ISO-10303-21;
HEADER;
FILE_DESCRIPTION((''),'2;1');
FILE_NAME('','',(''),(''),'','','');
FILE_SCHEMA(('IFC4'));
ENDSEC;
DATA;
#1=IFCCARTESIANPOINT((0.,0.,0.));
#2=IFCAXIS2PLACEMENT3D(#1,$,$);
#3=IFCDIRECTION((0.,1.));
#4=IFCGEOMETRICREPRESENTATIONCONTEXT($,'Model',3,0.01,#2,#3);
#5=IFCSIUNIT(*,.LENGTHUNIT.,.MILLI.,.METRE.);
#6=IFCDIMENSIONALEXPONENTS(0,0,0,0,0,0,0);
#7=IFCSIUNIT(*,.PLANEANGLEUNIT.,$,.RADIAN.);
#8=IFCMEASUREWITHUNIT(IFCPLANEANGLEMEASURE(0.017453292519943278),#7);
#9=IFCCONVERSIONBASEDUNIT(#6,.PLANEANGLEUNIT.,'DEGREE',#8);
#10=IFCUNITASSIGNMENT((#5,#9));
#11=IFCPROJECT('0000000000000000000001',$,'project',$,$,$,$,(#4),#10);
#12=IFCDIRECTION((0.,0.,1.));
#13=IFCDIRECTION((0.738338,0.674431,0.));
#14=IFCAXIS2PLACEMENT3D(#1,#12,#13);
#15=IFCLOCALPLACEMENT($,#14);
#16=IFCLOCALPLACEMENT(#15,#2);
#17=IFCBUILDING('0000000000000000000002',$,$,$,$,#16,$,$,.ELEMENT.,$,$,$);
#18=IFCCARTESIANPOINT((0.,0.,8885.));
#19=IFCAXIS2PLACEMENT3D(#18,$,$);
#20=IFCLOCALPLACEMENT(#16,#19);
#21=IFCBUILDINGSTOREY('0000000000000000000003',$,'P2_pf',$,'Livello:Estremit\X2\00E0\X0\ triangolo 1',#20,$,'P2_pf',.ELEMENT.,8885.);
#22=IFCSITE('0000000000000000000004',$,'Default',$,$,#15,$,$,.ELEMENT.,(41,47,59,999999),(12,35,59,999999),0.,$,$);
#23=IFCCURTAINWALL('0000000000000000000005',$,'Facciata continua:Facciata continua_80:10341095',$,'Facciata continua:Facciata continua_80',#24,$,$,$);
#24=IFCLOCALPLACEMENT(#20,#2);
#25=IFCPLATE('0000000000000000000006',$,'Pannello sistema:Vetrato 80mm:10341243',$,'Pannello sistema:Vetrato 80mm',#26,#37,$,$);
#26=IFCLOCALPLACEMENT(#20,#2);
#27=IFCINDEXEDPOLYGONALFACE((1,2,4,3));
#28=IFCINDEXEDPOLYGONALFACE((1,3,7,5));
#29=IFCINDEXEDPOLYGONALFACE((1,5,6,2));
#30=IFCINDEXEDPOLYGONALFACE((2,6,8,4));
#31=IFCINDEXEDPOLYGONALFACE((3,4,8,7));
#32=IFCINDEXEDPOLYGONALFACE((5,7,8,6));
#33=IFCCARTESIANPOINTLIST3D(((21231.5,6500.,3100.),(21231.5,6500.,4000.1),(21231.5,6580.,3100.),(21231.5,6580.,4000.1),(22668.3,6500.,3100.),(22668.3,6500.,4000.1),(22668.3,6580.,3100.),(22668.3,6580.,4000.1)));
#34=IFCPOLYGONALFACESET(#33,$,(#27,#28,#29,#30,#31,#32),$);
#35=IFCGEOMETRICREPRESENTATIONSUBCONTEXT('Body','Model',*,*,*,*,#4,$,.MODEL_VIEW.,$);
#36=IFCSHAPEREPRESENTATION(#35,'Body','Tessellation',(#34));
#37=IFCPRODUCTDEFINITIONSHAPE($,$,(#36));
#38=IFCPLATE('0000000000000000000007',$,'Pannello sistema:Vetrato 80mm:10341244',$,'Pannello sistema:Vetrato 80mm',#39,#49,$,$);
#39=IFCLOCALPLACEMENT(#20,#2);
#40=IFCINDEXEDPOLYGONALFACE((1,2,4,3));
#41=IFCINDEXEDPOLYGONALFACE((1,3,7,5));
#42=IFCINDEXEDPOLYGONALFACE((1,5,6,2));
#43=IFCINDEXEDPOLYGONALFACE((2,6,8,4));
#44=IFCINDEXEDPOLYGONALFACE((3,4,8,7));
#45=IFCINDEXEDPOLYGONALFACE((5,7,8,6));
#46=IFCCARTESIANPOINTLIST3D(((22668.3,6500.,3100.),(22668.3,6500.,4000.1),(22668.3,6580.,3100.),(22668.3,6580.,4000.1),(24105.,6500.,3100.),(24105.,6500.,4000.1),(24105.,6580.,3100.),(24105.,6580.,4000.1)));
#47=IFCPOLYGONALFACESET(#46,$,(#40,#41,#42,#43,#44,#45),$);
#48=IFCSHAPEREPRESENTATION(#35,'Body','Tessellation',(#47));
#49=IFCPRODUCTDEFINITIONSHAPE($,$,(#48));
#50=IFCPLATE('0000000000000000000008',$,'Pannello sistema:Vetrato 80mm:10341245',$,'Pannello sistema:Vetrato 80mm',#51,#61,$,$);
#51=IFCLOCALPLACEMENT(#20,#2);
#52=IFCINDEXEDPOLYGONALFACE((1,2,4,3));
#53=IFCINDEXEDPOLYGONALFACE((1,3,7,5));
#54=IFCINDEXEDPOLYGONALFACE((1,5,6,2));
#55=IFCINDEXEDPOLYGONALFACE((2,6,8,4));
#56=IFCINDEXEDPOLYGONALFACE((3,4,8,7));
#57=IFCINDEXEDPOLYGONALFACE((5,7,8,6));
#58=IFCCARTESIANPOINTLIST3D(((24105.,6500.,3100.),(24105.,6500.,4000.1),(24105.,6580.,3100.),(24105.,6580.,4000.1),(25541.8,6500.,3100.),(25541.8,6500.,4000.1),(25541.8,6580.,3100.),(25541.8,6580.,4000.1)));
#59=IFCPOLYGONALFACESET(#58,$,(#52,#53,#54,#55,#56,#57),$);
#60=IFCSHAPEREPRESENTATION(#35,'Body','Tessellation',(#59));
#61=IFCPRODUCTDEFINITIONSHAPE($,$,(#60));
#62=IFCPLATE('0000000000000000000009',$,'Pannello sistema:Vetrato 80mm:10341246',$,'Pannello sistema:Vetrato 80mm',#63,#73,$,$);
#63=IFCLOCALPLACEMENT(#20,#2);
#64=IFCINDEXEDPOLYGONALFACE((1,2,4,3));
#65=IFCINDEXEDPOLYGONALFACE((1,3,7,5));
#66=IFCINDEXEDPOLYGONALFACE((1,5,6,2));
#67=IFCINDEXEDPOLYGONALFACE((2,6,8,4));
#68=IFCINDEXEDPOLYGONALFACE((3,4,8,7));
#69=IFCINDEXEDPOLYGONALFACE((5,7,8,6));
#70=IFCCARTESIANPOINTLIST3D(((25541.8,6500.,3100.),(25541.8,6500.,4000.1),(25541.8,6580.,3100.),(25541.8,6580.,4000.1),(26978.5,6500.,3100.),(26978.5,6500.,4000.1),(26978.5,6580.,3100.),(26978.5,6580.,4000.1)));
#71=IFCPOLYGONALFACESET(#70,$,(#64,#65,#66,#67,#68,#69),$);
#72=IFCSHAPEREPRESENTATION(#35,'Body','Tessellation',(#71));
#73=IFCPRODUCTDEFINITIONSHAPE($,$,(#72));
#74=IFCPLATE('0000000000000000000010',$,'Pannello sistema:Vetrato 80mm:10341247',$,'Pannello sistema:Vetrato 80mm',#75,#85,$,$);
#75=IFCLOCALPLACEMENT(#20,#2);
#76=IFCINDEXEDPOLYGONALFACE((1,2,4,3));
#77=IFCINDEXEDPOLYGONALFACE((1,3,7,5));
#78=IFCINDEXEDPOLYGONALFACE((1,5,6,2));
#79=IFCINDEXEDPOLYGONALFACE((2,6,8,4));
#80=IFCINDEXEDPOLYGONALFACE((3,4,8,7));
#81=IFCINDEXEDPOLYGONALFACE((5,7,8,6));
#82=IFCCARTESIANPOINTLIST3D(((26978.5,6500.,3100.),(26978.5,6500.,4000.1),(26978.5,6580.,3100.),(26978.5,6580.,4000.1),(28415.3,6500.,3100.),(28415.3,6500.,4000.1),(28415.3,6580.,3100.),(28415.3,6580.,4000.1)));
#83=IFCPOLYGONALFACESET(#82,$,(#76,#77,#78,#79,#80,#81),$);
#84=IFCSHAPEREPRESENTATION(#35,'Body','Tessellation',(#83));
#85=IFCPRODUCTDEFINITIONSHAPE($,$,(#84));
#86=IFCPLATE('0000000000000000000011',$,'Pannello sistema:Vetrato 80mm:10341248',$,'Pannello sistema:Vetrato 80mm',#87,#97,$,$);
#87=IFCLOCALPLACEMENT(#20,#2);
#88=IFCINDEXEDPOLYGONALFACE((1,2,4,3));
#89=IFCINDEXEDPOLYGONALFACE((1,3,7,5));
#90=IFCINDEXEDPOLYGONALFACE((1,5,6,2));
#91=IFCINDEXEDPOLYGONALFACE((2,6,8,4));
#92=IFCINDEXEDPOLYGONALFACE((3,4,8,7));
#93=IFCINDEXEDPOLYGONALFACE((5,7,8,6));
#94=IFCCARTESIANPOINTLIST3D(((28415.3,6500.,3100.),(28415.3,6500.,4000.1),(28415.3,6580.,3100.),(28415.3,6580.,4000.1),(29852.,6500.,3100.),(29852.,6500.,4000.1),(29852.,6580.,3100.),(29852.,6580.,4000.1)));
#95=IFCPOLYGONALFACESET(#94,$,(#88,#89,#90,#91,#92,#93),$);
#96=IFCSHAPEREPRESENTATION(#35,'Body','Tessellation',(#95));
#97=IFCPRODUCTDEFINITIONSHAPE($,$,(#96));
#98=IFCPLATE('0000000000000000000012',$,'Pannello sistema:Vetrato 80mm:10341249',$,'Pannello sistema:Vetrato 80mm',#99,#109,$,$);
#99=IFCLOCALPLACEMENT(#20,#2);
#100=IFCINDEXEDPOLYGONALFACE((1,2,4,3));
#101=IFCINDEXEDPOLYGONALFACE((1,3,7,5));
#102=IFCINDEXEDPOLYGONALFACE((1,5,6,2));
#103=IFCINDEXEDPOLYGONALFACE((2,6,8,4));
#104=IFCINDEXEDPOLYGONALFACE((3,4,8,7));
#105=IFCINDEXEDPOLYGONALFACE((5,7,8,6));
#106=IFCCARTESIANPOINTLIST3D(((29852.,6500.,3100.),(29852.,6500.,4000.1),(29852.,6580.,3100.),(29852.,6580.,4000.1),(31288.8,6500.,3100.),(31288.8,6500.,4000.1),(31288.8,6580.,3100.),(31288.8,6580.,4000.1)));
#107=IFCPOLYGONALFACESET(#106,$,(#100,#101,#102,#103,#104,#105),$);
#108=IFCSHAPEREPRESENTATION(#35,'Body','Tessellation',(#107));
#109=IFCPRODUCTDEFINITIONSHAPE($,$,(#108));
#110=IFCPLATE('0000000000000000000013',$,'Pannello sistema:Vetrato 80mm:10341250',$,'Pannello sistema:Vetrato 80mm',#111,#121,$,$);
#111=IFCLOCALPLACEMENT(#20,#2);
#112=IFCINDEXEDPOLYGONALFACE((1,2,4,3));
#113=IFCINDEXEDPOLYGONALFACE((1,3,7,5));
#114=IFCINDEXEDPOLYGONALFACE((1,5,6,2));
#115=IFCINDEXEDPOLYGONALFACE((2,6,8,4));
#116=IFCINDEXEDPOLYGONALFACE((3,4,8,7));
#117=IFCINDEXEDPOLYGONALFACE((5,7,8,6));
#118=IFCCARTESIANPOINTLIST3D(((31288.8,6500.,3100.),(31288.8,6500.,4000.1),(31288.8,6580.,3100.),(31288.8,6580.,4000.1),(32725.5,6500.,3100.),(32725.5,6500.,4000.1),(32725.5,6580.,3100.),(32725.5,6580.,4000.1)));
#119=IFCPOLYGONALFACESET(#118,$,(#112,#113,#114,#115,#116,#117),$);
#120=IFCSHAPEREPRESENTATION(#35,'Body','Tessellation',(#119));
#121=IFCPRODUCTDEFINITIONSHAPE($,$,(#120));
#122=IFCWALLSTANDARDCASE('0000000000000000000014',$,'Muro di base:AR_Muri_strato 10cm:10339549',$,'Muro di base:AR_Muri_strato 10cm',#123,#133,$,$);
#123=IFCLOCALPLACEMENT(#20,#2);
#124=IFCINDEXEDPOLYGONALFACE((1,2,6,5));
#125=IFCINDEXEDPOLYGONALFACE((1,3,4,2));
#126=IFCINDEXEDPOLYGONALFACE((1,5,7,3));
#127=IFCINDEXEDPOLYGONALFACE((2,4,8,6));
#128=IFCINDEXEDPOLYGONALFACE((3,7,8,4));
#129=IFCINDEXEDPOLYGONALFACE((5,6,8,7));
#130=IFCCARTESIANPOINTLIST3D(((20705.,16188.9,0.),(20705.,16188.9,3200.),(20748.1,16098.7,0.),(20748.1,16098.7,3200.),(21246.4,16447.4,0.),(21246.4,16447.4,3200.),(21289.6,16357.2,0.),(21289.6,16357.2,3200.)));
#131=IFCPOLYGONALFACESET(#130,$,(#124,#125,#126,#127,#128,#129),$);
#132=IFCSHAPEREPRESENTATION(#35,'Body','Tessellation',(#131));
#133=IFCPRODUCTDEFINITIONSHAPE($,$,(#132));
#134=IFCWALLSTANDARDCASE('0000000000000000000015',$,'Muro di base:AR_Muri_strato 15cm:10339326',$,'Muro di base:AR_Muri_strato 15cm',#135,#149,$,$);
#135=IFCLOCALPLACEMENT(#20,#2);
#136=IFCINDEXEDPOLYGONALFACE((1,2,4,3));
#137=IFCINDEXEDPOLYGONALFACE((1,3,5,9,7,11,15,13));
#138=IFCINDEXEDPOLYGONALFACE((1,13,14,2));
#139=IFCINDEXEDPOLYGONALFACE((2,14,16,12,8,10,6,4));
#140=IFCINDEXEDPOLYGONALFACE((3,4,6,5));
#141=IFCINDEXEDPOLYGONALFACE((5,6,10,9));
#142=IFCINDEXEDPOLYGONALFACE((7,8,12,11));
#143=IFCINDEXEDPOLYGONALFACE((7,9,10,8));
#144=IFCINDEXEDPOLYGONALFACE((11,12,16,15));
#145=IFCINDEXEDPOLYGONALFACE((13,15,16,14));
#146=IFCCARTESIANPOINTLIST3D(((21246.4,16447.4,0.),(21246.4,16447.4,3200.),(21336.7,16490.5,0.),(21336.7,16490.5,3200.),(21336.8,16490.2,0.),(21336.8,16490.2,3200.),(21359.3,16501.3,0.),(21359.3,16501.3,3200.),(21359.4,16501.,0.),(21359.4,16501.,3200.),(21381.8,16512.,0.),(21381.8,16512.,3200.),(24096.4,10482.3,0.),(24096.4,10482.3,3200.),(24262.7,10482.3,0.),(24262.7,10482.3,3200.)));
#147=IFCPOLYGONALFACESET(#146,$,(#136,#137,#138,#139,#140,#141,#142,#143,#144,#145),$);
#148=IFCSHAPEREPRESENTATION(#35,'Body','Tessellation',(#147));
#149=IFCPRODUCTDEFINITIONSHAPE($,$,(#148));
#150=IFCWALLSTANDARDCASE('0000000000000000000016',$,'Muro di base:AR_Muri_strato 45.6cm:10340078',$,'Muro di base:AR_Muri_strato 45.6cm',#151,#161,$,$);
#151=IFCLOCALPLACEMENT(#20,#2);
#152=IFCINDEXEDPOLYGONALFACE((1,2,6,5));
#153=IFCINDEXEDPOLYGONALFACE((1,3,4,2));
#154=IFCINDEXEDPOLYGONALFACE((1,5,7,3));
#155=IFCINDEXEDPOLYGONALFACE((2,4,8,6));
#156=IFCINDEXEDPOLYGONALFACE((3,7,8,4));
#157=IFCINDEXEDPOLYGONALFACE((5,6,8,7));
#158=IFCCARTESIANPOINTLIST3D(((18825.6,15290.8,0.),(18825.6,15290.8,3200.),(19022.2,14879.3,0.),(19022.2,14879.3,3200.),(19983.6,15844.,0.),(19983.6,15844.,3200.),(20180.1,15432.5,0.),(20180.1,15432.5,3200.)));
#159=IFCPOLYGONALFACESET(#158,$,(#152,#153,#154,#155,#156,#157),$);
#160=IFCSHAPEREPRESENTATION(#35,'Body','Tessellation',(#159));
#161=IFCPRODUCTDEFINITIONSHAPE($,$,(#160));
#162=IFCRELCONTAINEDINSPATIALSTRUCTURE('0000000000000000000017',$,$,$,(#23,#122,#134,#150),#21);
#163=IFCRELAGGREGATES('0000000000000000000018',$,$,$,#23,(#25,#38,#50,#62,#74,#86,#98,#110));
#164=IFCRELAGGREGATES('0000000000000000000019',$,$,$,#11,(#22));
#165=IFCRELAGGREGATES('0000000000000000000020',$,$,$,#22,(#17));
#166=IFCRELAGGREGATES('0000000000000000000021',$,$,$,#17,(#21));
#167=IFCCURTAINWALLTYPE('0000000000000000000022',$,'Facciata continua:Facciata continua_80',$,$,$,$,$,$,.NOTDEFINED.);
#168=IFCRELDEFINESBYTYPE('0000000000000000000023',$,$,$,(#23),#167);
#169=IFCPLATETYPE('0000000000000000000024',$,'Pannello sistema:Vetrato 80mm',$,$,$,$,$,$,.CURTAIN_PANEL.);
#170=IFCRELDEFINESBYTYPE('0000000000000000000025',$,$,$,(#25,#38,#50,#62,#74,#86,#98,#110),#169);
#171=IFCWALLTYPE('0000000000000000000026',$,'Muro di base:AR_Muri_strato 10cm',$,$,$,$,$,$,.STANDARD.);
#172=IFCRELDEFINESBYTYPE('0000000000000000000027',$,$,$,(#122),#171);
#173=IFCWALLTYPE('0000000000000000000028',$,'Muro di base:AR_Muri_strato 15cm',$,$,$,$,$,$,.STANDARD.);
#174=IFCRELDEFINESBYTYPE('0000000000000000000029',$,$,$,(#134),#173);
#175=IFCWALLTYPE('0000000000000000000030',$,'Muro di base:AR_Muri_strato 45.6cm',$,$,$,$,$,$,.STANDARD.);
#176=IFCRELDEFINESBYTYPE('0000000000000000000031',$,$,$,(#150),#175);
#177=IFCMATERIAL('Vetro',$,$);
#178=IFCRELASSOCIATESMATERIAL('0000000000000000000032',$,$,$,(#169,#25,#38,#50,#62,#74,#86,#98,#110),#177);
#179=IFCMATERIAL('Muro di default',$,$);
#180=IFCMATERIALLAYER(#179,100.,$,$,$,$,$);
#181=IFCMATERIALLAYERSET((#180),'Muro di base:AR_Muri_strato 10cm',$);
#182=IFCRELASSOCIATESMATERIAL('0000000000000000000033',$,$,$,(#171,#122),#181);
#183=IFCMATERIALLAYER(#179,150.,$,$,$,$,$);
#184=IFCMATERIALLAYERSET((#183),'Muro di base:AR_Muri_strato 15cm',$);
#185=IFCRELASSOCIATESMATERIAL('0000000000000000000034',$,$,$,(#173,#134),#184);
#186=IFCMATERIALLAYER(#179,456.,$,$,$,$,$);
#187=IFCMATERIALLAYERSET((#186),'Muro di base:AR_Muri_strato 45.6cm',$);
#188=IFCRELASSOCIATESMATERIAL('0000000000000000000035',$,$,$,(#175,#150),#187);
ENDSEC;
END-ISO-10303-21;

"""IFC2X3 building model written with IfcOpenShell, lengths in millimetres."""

from ifc_helpers import new_model, entity, si_unit, converted_unit, direction, frame, frame_2d, origin, origin_2d_with_axis, place, context, subcontext, project, spatial, polyline, rectangle, outline, extrude, clip, bounded_halfspace, source, transform, mapped, material, layer, layer_set, layer_usage, type_object, type_shapes, element, aggregate, save


model = new_model("IFC2X3")

# Units and contexts
model_context = context("Model", 3, precision=0.01, world=origin(), true_north=direction((0.0, 1.0)))
body_context = subcontext(model_context, "Body", "Model", "MODEL_VIEW")
ifc_project = project(units=[si_unit("LENGTHUNIT", "METRE", prefix="MILLI"), converted_unit("PLANEANGLEUNIT", "DEGREE", entity("IfcPlaneAngleMeasure", 0.017453292519943278), si_unit("PLANEANGLEUNIT", "RADIAN"), dimensions=[0, 0, 0, 0, 0, 0, 0])], contexts=[model_context])

# Site, building, storey
site_placement = place(None, frame((0.0, 0.0, 0.0), z_axis=(0.0, 0.0, 1.0), x_axis=(0.738338, 0.674431, 0.0)))
site = spatial("IfcSite", under=ifc_project, at=site_placement, Name="Default", CompositionType="ELEMENT", RefLatitude=(41, 47, 59, 999999), RefLongitude=(12, 35, 59, 999999), RefElevation=0.0)
building_placement = place(site_placement, origin())
building = spatial("IfcBuilding", under=site, at=building_placement, CompositionType="ELEMENT")
storey_placement = place(building_placement, frame((0.0, 0.0, 8885.0)))
storey = spatial("IfcBuildingStorey", under=building, at=storey_placement, Name="P2_pf", ObjectType="Livello:Estremità triangolo 1", LongName="P2_pf", CompositionType="ELEMENT", Elevation=8885.0)

# Shared definitions
ifc_material_1 = material(Name="Vetro")

# Curtain wall, plates
curtain_wall_type_1 = type_object("IfcCurtainWallType", Name="Facciata continua:Facciata continua_80", PredefinedType="NOTDEFINED")
curtain_wall_1_placement = place(storey_placement, frame((0.0, 0.0, -8885.0)))
curtain_wall_1 = element("IfcCurtainWall", 1, at=curtain_wall_1_placement, inside=storey, type_object=curtain_wall_type_1, Name="Facciata continua:Facciata continua_80:10341095", ObjectType="Facciata continua:Facciata continua_80")
plate_type_1 = type_object("IfcPlateType", Name="Pannello sistema:Vetrato 80mm", PredefinedType="CURTAIN_PANEL", material=ifc_material_1)
shared_shape_1 = source(origin(), body_context, "Body", "SweptSolid", [
    extrude(rectangle(XDim=80.0, YDim=1436.8, at=origin_2d_with_axis()), frame((0.0, -40.0, 0.0), z_axis=(0.0, 0.0, 1.0), x_axis=(0.0, 1.0, 0.0)), (0.0, 0.0, 1.0), 900.1),
])
type_shapes(plate_type_1, [shared_shape_1])
plate_1_placement = place(curtain_wall_1_placement, frame((21949.9, 6580.0, 11985.0)))
plate_1 = element("IfcPlate", 2, at=plate_1_placement, type_object=plate_type_1, material=ifc_material_1, Name="Pannello sistema:Vetrato 80mm:10341243", ObjectType="Pannello sistema:Vetrato 80mm", context=body_context, shape_type="MappedRepresentation", body=[
    mapped(shared_shape_1, transform((0.0, 0.0, 0.0), scale=1.0)),
])
plate_2_placement = place(curtain_wall_1_placement, frame((23386.6, 6580.0, 11985.0)))
plate_2 = element("IfcPlate", 3, at=plate_2_placement, type_object=plate_type_1, material=ifc_material_1, Name="Pannello sistema:Vetrato 80mm:10341244", ObjectType="Pannello sistema:Vetrato 80mm", context=body_context, shape_type="MappedRepresentation", body=[
    mapped(shared_shape_1, transform((0.0, 0.0, 0.0), scale=1.0)),
])
plate_3_placement = place(curtain_wall_1_placement, frame((24823.4, 6580.0, 11985.0)))
plate_3 = element("IfcPlate", 4, at=plate_3_placement, type_object=plate_type_1, material=ifc_material_1, Name="Pannello sistema:Vetrato 80mm:10341245", ObjectType="Pannello sistema:Vetrato 80mm", context=body_context, shape_type="MappedRepresentation", body=[
    mapped(shared_shape_1, transform((0.0, 0.0, 0.0), scale=1.0)),
])
plate_4_placement = place(curtain_wall_1_placement, frame((26260.2, 6580.0, 11985.0)))
plate_4 = element("IfcPlate", 5, at=plate_4_placement, type_object=plate_type_1, material=ifc_material_1, Name="Pannello sistema:Vetrato 80mm:10341246", ObjectType="Pannello sistema:Vetrato 80mm", context=body_context, shape_type="MappedRepresentation", body=[
    mapped(shared_shape_1, transform((0.0, 0.0, 0.0), scale=1.0)),
])
plate_5_placement = place(curtain_wall_1_placement, frame((27696.9, 6580.0, 11985.0)))
plate_5 = element("IfcPlate", 6, at=plate_5_placement, type_object=plate_type_1, material=ifc_material_1, Name="Pannello sistema:Vetrato 80mm:10341247", ObjectType="Pannello sistema:Vetrato 80mm", context=body_context, shape_type="MappedRepresentation", body=[
    mapped(shared_shape_1, transform((0.0, 0.0, 0.0), scale=1.0)),
])
plate_6_placement = place(curtain_wall_1_placement, frame((29133.7, 6580.0, 11985.0)))
plate_6 = element("IfcPlate", 7, at=plate_6_placement, type_object=plate_type_1, material=ifc_material_1, Name="Pannello sistema:Vetrato 80mm:10341248", ObjectType="Pannello sistema:Vetrato 80mm", context=body_context, shape_type="MappedRepresentation", body=[
    mapped(shared_shape_1, transform((0.0, 0.0, 0.0), scale=1.0)),
])
plate_7_placement = place(curtain_wall_1_placement, frame((30570.4, 6580.0, 11985.0)))
plate_7 = element("IfcPlate", 8, at=plate_7_placement, type_object=plate_type_1, material=ifc_material_1, Name="Pannello sistema:Vetrato 80mm:10341249", ObjectType="Pannello sistema:Vetrato 80mm", context=body_context, shape_type="MappedRepresentation", body=[
    mapped(shared_shape_1, transform((0.0, 0.0, 0.0), scale=1.0)),
])
plate_8_placement = place(curtain_wall_1_placement, frame((32007.2, 6580.0, 11985.0)))
plate_8 = element("IfcPlate", 9, at=plate_8_placement, type_object=plate_type_1, material=ifc_material_1, Name="Pannello sistema:Vetrato 80mm:10341250", ObjectType="Pannello sistema:Vetrato 80mm", context=body_context, shape_type="MappedRepresentation", body=[
    mapped(shared_shape_1, transform((0.0, 0.0, 0.0), scale=1.0)),
])
aggregate(curtain_wall_1, [plate_1, plate_2, plate_3, plate_4, plate_5, plate_6, plate_7, plate_8])

# Walls
ifc_material_2 = material(Name="Muro di default")
ifc_layer_1 = layer(ifc_material_2, 100.0)
ifc_layer_set_1 = layer_set([ifc_layer_1], Name="Muro di base:AR_Muri_strato 10cm")
ifc_layer_usage_1 = layer_usage(ifc_layer_set_1, "AXIS2", "NEGATIVE", 50.0)
wall_type_1 = type_object("IfcWallType", Name="Muro di base:AR_Muri_strato 10cm", PredefinedType="STANDARD", material=ifc_layer_set_1)
wall_1_placement = place(storey_placement, frame((21268.0, 16402.3, 0.0), z_axis=(0.0, 0.0, 1.0), x_axis=(-0.902436, -0.430824, 0.0)))
element("IfcWallStandardCase", 10, at=wall_1_placement, inside=storey, type_object=wall_type_1, material=ifc_layer_usage_1, Name="Muro di base:AR_Muri_strato 10cm:10339549", ObjectType="Muro di base:AR_Muri_strato 10cm", context=body_context, shape_type="SweptSolid", body=[
    extrude(outline(polyline([(600.0, -50.0), (600.0, 50.0), (0.0, 50.0), (0.0, -50.0), (600.0, -50.0)])), origin(), (0.0, 0.0, 1.0), 3200.0),
])
ifc_layer_2 = layer(ifc_material_2, 150.0)
ifc_layer_set_2 = layer_set([ifc_layer_2], Name="Muro di base:AR_Muri_strato 15cm")
ifc_layer_usage_2 = layer_usage(ifc_layer_set_2, "AXIS2", "NEGATIVE", 75.0)
wall_type_2 = type_object("IfcWallType", Name="Muro di base:AR_Muri_strato 15cm", PredefinedType="STANDARD", material=ifc_layer_set_2)
wall_2_placement = place(storey_placement, frame((24195.0, 10449.9, 0.0), z_axis=(0.0, 0.0, 1.0), x_axis=(-0.431099, 0.902305, 0.0)))
element("IfcWallStandardCase", 11, at=wall_2_placement, inside=storey, type_object=wall_type_2, material=ifc_layer_usage_2, Name="Muro di base:AR_Muri_strato 15cm:10339326", ObjectType="Muro di base:AR_Muri_strato 15cm", context=body_context, shape_type="Clipping", body=[
    clip(extrude(outline(polyline([(6682.6, -75.0), (6682.6, -50.0), (6682.4, -50.0), (6682.3, -25.0), (6682.6, -25.0), (6682.7, 75.0), (6582.7, 75.0), (71.7, 75.0), (0.0, -75.0), (221.7, -75.0), (6682.6, -75.0)])), origin(), (0.0, 0.0, 1.0), 3200.0), bounded_halfspace(frame((6682.4, -50.0, 3200.0), z_axis=(-0.999992, -0.003905, 0.0), x_axis=(-0.003905, 0.999992, 0.0)), True, frame((6682.4, -50.0, 3200.0), z_axis=(-0.999992, -0.003905, 0.0), x_axis=(-0.003905, 0.999992, 0.0)), polyline([(0.0, 0.0), (25.0, 0.0), (25.0, 3200.0), (0.0, 3200.0), (0.0, 0.0)]))),
])
ifc_layer_3 = layer(ifc_material_2, 456.0)
ifc_layer_set_3 = layer_set([ifc_layer_3], Name="Muro di base:AR_Muri_strato 45.6cm")
ifc_layer_usage_3 = layer_usage(ifc_layer_set_3, "AXIS2", "NEGATIVE", 228.0)
wall_type_3 = type_object("IfcWallType", Name="Muro di base:AR_Muri_strato 45.6cm", PredefinedType="STANDARD", material=ifc_layer_set_3)
wall_3_placement = place(storey_placement, frame((18923.9, 15085.0, 0.0), z_axis=(0.0, 0.0, 1.0), x_axis=(0.902305, 0.431099, 0.0)))
element("IfcWallStandardCase", 12, at=wall_3_placement, inside=storey, type_object=wall_type_3, material=ifc_layer_usage_3, Name="Muro di base:AR_Muri_strato 45.6cm:10340078", ObjectType="Muro di base:AR_Muri_strato 45.6cm", context=body_context, shape_type="SweptSolid", body=[
    extrude(rectangle(XDim=1283.3, YDim=456.0, at=frame_2d((641.7, 0.0), x_axis=(-1.0, 0.0))), origin(), (0.0, 0.0, 1.0), 3200.0),
])

save(model, "model.ifc")
